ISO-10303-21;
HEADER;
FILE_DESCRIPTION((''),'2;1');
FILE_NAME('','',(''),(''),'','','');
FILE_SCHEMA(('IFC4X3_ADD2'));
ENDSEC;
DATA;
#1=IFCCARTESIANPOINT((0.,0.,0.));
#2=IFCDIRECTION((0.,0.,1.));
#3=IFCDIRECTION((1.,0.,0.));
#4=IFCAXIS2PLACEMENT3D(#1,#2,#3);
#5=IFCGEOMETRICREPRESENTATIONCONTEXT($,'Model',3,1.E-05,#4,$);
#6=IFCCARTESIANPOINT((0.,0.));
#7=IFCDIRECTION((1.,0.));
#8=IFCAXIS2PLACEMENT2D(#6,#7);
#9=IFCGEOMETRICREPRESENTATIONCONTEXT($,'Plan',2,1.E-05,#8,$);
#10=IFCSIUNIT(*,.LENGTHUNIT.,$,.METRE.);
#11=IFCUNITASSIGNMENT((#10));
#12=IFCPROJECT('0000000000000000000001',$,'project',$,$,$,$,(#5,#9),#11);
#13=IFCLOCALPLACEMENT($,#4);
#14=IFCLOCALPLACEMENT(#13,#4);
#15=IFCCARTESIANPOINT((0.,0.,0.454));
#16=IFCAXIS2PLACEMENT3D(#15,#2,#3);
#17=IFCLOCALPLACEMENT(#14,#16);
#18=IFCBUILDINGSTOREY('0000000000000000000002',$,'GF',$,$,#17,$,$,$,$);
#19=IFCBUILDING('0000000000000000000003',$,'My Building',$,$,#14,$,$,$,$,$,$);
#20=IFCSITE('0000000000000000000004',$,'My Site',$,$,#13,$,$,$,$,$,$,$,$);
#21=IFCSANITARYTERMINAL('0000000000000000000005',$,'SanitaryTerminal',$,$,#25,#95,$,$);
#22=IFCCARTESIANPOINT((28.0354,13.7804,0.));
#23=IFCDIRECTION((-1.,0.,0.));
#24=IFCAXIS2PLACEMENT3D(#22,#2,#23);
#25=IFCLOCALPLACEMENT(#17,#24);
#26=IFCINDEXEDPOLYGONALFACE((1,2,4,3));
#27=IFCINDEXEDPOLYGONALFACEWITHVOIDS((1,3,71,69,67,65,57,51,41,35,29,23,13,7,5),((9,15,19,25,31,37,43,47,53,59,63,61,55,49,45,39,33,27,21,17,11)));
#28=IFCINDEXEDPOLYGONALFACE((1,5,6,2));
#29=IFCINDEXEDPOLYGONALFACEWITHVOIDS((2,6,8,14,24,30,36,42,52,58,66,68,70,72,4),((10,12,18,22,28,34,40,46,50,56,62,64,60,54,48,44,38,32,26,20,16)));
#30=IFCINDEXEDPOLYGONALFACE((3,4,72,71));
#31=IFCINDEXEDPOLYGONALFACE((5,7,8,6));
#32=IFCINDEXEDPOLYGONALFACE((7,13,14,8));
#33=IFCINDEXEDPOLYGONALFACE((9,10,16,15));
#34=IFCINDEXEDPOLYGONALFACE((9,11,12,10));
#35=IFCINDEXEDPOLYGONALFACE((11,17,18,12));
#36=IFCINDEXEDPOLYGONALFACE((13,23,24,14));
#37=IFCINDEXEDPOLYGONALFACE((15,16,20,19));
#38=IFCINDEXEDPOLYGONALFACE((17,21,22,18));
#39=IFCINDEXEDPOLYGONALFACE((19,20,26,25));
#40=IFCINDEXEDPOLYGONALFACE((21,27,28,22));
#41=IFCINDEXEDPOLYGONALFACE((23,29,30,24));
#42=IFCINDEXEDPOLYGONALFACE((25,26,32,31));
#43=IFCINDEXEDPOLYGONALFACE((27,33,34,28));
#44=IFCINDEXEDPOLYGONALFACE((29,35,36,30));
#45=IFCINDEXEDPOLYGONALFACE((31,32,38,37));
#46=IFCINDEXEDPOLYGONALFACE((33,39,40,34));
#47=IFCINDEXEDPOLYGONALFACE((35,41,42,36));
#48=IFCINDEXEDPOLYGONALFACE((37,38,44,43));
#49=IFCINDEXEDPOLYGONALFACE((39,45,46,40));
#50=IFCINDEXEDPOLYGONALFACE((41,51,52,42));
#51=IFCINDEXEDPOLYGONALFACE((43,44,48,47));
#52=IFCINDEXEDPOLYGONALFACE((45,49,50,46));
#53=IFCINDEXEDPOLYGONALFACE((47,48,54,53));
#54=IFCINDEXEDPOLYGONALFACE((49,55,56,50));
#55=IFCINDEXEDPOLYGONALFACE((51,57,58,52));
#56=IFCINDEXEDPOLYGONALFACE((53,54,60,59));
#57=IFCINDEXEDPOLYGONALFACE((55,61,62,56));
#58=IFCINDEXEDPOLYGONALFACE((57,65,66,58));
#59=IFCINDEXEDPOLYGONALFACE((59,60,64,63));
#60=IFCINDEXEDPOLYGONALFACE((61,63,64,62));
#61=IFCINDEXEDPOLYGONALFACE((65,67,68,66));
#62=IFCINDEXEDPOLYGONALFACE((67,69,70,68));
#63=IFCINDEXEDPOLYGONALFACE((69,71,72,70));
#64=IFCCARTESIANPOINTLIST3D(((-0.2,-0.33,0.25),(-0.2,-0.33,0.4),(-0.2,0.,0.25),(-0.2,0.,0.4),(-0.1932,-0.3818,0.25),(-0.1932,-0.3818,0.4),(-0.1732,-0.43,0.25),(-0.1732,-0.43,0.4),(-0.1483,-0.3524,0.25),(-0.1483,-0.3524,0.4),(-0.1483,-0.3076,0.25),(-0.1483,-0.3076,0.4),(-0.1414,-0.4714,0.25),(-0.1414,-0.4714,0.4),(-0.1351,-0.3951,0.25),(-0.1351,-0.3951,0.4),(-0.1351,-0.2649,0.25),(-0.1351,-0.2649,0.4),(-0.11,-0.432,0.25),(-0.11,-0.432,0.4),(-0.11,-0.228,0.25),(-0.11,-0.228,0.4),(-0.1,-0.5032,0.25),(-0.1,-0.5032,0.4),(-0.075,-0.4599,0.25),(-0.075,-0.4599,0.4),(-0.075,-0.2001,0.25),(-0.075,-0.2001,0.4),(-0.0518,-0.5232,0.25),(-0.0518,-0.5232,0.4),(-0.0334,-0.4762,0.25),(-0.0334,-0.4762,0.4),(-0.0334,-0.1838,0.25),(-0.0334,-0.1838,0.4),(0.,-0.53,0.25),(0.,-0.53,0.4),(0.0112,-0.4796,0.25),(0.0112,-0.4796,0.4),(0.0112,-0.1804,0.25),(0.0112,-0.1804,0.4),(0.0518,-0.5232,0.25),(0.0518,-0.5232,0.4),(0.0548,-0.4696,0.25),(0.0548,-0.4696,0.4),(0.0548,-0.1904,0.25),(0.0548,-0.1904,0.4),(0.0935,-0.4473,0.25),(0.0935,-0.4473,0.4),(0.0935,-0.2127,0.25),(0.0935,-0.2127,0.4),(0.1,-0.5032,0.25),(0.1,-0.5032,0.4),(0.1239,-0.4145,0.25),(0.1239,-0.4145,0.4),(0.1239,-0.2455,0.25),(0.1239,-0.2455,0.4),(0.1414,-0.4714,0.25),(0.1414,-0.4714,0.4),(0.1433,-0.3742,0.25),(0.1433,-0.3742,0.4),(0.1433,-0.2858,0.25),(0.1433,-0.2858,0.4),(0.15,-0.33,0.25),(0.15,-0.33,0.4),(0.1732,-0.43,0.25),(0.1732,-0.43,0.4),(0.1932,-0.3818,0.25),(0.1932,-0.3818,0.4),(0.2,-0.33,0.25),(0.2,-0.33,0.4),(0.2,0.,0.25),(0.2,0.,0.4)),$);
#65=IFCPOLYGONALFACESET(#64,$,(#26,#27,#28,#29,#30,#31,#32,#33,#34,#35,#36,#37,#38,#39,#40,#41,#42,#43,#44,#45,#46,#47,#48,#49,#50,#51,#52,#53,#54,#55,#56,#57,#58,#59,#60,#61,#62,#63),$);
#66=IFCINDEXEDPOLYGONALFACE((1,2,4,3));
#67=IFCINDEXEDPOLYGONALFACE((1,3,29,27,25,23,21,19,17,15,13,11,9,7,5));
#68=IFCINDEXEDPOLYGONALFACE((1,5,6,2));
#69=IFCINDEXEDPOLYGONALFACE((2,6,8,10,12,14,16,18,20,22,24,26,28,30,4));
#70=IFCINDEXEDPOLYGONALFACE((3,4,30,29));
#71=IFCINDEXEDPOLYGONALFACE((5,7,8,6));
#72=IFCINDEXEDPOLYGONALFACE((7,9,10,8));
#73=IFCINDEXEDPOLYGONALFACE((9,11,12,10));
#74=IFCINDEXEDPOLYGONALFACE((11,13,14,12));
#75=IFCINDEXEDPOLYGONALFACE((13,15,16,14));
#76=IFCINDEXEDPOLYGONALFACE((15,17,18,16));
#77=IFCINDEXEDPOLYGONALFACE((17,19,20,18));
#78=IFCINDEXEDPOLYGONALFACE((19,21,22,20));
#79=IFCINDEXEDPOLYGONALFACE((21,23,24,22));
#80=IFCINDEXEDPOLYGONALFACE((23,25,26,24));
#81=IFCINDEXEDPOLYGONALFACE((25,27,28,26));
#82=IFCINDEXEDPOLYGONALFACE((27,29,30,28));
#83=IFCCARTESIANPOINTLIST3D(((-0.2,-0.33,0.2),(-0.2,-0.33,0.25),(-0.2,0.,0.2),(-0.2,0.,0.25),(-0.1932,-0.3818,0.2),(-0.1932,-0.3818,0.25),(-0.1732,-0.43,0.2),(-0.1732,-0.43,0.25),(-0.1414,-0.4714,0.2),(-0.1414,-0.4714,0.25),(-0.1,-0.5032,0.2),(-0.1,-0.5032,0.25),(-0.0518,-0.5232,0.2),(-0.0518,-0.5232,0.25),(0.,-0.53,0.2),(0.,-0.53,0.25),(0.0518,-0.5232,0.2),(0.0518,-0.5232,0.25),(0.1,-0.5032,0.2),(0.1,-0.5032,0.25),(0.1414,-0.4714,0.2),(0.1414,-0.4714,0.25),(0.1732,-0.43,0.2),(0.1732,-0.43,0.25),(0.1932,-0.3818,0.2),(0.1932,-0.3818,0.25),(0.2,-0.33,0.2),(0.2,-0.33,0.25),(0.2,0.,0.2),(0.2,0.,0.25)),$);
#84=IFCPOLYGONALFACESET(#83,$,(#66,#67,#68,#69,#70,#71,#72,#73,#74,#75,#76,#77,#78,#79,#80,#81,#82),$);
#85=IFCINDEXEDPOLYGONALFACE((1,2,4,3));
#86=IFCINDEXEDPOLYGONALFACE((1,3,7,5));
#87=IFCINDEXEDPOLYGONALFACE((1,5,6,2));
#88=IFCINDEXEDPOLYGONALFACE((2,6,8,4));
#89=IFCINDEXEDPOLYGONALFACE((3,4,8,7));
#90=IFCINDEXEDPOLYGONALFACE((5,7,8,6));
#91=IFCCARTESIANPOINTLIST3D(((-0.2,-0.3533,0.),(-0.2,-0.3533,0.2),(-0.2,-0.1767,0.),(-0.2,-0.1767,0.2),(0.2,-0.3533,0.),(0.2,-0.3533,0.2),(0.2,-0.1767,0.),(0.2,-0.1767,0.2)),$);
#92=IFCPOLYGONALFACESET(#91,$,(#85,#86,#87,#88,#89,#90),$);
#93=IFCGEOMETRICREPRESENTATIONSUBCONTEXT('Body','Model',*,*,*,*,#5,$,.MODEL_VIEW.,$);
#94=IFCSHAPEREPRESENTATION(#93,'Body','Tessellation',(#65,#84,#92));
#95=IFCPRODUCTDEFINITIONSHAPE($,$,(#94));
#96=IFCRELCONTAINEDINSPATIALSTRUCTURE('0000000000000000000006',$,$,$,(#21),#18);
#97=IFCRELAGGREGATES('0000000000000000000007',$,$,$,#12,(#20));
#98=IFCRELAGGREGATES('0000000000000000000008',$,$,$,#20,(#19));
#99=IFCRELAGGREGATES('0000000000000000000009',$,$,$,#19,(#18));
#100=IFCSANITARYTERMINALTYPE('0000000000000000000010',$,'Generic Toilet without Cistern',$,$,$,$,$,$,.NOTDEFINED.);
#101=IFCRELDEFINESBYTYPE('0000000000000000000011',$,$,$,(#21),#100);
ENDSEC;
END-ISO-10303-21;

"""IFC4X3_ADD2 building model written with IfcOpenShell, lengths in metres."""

from ifc_helpers import new_model, entity, si_unit, frame, frame_2d, origin_with_axes, origin_2d_with_axis, place, context, subcontext, project, spatial, line, arc, indexed_curve, circle_curve, outline, extrude, shape, source, transform, mapped, type_object, type_shapes, element, save


model = new_model("IFC4X3_ADD2")

# Units and contexts
model_context = context("Model", 3, precision=1e-05, world=origin_with_axes())
plan_context = context("Plan", 2, precision=1e-05, world=origin_2d_with_axis())
body_context_1 = subcontext(model_context, "Body", "Model", "MODEL_VIEW")
body_context_2 = subcontext(plan_context, "Body", "Plan", "PLAN_VIEW")
ifc_project = project(units=[si_unit("LENGTHUNIT", "METRE")], contexts=[model_context, plan_context])

# Site, building, storey
site_placement = place(None, origin_with_axes())
site = spatial("IfcSite", under=ifc_project, at=site_placement, Name="My Site")
building_placement = place(site_placement, origin_with_axes())
building = spatial("IfcBuilding", under=site, at=building_placement, Name="My Building")
storey_placement = place(building_placement, frame((0.0, 0.0, 0.454), z_axis=(0.0, 0.0, 1.0), x_axis=(1.0, 0.0, 0.0)))
storey = spatial("IfcBuildingStorey", under=building, at=storey_placement, Name="GF")

# Sanitary terminal
sanitary_terminal_type_1 = type_object("IfcSanitaryTerminalType", Name="Generic Toilet without Cistern", PredefinedType="NOTDEFINED")
shared_shape_1 = source(origin_with_axes(), body_context_1, "Body", "SweptSolid", [
    extrude(outline(indexed_curve([(-0.2, 0.0), (0.2, 0.0), (0.2, -0.33), (0.1414, -0.4714), (0.0, -0.53), (-0.1414, -0.4714), (-0.2, -0.33)], segments=[line(1, 2), line(2, 3), arc(3, 4, 5), arc(5, 6, 7), line(7, 1)]), holes=[circle_curve(frame_2d((0.0, -0.33)), 0.15)]), frame((0.0, 0.0, 0.25), z_axis=(0.0, 0.0, 1.0), x_axis=(1.0, 0.0, 0.0)), (0.0, 0.0, 1.0), 0.15),
    extrude(outline(indexed_curve([(-0.2, 0.0), (0.2, 0.0), (0.2, -0.33), (0.1414, -0.4714), (0.0, -0.53), (-0.1414, -0.4714), (-0.2, -0.33)], segments=[line(1, 2), line(2, 3), arc(3, 4, 5), arc(5, 6, 7), line(7, 1)])), frame((0.0, 0.0, 0.2), z_axis=(0.0, 0.0, 1.0), x_axis=(1.0, 0.0, 0.0)), (0.0, 0.0, 1.0), 0.05),
    extrude(outline(indexed_curve([(-0.2, -0.1767), (0.2, -0.1767), (0.2, -0.3533), (-0.2, -0.3533)], segments=[line(1, 2, 3, 4, 1)])), origin_with_axes(), (0.0, 0.0, 1.0), 0.2),
])
shared_shape_2 = source(origin_with_axes(), body_context_2, "Body", "Annotation2D", [
    entity("IfcGeometricCurveSet", [entity("IfcIndexedPolyCurve", entity("IfcCartesianPointList2D", [[-0.1068, -0.124], [-0.0957, -0.1129], [-0.0804, -0.1088], [0.0804, -0.1088], [0.0957, -0.1129], [0.1068, -0.124], [0.1109, -0.1393], [0.1109, -0.3476], [0.1025, -0.3926], [0.0784, -0.4308], [0.0424, -0.4563], [0.0, -0.4652], [-0.0424, -0.4563], [-0.0784, -0.4308], [-0.1025, -0.3926], [-0.1109, -0.3476], [-0.1109, -0.1393]]), [entity("IfcLineIndex", [1, 2, 3, 4, 5, 6, 7, 8, 9, 10, 11, 12, 13, 14, 15, 16, 17, 1])]), entity("IfcIndexedPolyCurve", entity("IfcCartesianPointList2D", [[-0.1962, -0.2314], [-0.1848, -0.301], [-0.1764, -0.3339], [-0.1663, -0.3651], [-0.1546, -0.3944], [-0.1414, -0.4213], [-0.1269, -0.4458], [-0.1111, -0.4675], [-0.0943, -0.4862], [-0.0765, -0.5018], [-0.0581, -0.514], [-0.039, -0.5229], [-0.0196, -0.5282], [0.0, -0.53], [0.0196, -0.5282], [0.039, -0.5229], [0.0581, -0.514], [0.0765, -0.5018], [0.0943, -0.4862], [0.1111, -0.4675], [0.1269, -0.4458], [0.1414, -0.4213], [0.1546, -0.3944], [0.1663, -0.3651], [0.1764, -0.3339], [0.1848, -0.301], [0.1962, -0.2314], [0.2, -0.159], [0.1872, 0.0], [-0.1872, 0.0], [-0.2, -0.159]]), [entity("IfcLineIndex", [1, 2, 3, 4, 5, 6, 7, 8, 9, 10, 11, 12, 13, 14, 15, 16, 17, 18, 19, 20, 21, 22, 23, 24, 25, 26, 27, 28, 29, 30, 31, 1])])]),
])
type_shapes(sanitary_terminal_type_1, [shared_shape_1, shared_shape_2])
sanitary_terminal_1_placement = place(storey_placement, frame((28.0354, 13.7804, 0.0), z_axis=(0.0, 0.0, 1.0), x_axis=(-1.0, 0.0, 0.0)))
element("IfcSanitaryTerminal", 1, at=sanitary_terminal_1_placement, inside=storey, type_object=sanitary_terminal_type_1, Name="SanitaryTerminal", shapes=[
    shape(body_context_1, "Body", "MappedRepresentation", [mapped(shared_shape_1, transform((0.0, 0.0, 0.0), x_axis=(1.0, 0.0, 0.0), y_axis=(0.0, 1.0, 0.0), z_axis=(0.0, 0.0, 1.0), scale=1.0))]),
    shape(body_context_2, "Body", "MappedRepresentation", [mapped(shared_shape_2, transform((0.0, 0.0, 0.0), x_axis=(1.0, 0.0, 0.0), y_axis=(0.0, 1.0, 0.0), z_axis=(0.0, 0.0, 1.0), scale=1.0))]),
])

save(model, "model.ifc")
